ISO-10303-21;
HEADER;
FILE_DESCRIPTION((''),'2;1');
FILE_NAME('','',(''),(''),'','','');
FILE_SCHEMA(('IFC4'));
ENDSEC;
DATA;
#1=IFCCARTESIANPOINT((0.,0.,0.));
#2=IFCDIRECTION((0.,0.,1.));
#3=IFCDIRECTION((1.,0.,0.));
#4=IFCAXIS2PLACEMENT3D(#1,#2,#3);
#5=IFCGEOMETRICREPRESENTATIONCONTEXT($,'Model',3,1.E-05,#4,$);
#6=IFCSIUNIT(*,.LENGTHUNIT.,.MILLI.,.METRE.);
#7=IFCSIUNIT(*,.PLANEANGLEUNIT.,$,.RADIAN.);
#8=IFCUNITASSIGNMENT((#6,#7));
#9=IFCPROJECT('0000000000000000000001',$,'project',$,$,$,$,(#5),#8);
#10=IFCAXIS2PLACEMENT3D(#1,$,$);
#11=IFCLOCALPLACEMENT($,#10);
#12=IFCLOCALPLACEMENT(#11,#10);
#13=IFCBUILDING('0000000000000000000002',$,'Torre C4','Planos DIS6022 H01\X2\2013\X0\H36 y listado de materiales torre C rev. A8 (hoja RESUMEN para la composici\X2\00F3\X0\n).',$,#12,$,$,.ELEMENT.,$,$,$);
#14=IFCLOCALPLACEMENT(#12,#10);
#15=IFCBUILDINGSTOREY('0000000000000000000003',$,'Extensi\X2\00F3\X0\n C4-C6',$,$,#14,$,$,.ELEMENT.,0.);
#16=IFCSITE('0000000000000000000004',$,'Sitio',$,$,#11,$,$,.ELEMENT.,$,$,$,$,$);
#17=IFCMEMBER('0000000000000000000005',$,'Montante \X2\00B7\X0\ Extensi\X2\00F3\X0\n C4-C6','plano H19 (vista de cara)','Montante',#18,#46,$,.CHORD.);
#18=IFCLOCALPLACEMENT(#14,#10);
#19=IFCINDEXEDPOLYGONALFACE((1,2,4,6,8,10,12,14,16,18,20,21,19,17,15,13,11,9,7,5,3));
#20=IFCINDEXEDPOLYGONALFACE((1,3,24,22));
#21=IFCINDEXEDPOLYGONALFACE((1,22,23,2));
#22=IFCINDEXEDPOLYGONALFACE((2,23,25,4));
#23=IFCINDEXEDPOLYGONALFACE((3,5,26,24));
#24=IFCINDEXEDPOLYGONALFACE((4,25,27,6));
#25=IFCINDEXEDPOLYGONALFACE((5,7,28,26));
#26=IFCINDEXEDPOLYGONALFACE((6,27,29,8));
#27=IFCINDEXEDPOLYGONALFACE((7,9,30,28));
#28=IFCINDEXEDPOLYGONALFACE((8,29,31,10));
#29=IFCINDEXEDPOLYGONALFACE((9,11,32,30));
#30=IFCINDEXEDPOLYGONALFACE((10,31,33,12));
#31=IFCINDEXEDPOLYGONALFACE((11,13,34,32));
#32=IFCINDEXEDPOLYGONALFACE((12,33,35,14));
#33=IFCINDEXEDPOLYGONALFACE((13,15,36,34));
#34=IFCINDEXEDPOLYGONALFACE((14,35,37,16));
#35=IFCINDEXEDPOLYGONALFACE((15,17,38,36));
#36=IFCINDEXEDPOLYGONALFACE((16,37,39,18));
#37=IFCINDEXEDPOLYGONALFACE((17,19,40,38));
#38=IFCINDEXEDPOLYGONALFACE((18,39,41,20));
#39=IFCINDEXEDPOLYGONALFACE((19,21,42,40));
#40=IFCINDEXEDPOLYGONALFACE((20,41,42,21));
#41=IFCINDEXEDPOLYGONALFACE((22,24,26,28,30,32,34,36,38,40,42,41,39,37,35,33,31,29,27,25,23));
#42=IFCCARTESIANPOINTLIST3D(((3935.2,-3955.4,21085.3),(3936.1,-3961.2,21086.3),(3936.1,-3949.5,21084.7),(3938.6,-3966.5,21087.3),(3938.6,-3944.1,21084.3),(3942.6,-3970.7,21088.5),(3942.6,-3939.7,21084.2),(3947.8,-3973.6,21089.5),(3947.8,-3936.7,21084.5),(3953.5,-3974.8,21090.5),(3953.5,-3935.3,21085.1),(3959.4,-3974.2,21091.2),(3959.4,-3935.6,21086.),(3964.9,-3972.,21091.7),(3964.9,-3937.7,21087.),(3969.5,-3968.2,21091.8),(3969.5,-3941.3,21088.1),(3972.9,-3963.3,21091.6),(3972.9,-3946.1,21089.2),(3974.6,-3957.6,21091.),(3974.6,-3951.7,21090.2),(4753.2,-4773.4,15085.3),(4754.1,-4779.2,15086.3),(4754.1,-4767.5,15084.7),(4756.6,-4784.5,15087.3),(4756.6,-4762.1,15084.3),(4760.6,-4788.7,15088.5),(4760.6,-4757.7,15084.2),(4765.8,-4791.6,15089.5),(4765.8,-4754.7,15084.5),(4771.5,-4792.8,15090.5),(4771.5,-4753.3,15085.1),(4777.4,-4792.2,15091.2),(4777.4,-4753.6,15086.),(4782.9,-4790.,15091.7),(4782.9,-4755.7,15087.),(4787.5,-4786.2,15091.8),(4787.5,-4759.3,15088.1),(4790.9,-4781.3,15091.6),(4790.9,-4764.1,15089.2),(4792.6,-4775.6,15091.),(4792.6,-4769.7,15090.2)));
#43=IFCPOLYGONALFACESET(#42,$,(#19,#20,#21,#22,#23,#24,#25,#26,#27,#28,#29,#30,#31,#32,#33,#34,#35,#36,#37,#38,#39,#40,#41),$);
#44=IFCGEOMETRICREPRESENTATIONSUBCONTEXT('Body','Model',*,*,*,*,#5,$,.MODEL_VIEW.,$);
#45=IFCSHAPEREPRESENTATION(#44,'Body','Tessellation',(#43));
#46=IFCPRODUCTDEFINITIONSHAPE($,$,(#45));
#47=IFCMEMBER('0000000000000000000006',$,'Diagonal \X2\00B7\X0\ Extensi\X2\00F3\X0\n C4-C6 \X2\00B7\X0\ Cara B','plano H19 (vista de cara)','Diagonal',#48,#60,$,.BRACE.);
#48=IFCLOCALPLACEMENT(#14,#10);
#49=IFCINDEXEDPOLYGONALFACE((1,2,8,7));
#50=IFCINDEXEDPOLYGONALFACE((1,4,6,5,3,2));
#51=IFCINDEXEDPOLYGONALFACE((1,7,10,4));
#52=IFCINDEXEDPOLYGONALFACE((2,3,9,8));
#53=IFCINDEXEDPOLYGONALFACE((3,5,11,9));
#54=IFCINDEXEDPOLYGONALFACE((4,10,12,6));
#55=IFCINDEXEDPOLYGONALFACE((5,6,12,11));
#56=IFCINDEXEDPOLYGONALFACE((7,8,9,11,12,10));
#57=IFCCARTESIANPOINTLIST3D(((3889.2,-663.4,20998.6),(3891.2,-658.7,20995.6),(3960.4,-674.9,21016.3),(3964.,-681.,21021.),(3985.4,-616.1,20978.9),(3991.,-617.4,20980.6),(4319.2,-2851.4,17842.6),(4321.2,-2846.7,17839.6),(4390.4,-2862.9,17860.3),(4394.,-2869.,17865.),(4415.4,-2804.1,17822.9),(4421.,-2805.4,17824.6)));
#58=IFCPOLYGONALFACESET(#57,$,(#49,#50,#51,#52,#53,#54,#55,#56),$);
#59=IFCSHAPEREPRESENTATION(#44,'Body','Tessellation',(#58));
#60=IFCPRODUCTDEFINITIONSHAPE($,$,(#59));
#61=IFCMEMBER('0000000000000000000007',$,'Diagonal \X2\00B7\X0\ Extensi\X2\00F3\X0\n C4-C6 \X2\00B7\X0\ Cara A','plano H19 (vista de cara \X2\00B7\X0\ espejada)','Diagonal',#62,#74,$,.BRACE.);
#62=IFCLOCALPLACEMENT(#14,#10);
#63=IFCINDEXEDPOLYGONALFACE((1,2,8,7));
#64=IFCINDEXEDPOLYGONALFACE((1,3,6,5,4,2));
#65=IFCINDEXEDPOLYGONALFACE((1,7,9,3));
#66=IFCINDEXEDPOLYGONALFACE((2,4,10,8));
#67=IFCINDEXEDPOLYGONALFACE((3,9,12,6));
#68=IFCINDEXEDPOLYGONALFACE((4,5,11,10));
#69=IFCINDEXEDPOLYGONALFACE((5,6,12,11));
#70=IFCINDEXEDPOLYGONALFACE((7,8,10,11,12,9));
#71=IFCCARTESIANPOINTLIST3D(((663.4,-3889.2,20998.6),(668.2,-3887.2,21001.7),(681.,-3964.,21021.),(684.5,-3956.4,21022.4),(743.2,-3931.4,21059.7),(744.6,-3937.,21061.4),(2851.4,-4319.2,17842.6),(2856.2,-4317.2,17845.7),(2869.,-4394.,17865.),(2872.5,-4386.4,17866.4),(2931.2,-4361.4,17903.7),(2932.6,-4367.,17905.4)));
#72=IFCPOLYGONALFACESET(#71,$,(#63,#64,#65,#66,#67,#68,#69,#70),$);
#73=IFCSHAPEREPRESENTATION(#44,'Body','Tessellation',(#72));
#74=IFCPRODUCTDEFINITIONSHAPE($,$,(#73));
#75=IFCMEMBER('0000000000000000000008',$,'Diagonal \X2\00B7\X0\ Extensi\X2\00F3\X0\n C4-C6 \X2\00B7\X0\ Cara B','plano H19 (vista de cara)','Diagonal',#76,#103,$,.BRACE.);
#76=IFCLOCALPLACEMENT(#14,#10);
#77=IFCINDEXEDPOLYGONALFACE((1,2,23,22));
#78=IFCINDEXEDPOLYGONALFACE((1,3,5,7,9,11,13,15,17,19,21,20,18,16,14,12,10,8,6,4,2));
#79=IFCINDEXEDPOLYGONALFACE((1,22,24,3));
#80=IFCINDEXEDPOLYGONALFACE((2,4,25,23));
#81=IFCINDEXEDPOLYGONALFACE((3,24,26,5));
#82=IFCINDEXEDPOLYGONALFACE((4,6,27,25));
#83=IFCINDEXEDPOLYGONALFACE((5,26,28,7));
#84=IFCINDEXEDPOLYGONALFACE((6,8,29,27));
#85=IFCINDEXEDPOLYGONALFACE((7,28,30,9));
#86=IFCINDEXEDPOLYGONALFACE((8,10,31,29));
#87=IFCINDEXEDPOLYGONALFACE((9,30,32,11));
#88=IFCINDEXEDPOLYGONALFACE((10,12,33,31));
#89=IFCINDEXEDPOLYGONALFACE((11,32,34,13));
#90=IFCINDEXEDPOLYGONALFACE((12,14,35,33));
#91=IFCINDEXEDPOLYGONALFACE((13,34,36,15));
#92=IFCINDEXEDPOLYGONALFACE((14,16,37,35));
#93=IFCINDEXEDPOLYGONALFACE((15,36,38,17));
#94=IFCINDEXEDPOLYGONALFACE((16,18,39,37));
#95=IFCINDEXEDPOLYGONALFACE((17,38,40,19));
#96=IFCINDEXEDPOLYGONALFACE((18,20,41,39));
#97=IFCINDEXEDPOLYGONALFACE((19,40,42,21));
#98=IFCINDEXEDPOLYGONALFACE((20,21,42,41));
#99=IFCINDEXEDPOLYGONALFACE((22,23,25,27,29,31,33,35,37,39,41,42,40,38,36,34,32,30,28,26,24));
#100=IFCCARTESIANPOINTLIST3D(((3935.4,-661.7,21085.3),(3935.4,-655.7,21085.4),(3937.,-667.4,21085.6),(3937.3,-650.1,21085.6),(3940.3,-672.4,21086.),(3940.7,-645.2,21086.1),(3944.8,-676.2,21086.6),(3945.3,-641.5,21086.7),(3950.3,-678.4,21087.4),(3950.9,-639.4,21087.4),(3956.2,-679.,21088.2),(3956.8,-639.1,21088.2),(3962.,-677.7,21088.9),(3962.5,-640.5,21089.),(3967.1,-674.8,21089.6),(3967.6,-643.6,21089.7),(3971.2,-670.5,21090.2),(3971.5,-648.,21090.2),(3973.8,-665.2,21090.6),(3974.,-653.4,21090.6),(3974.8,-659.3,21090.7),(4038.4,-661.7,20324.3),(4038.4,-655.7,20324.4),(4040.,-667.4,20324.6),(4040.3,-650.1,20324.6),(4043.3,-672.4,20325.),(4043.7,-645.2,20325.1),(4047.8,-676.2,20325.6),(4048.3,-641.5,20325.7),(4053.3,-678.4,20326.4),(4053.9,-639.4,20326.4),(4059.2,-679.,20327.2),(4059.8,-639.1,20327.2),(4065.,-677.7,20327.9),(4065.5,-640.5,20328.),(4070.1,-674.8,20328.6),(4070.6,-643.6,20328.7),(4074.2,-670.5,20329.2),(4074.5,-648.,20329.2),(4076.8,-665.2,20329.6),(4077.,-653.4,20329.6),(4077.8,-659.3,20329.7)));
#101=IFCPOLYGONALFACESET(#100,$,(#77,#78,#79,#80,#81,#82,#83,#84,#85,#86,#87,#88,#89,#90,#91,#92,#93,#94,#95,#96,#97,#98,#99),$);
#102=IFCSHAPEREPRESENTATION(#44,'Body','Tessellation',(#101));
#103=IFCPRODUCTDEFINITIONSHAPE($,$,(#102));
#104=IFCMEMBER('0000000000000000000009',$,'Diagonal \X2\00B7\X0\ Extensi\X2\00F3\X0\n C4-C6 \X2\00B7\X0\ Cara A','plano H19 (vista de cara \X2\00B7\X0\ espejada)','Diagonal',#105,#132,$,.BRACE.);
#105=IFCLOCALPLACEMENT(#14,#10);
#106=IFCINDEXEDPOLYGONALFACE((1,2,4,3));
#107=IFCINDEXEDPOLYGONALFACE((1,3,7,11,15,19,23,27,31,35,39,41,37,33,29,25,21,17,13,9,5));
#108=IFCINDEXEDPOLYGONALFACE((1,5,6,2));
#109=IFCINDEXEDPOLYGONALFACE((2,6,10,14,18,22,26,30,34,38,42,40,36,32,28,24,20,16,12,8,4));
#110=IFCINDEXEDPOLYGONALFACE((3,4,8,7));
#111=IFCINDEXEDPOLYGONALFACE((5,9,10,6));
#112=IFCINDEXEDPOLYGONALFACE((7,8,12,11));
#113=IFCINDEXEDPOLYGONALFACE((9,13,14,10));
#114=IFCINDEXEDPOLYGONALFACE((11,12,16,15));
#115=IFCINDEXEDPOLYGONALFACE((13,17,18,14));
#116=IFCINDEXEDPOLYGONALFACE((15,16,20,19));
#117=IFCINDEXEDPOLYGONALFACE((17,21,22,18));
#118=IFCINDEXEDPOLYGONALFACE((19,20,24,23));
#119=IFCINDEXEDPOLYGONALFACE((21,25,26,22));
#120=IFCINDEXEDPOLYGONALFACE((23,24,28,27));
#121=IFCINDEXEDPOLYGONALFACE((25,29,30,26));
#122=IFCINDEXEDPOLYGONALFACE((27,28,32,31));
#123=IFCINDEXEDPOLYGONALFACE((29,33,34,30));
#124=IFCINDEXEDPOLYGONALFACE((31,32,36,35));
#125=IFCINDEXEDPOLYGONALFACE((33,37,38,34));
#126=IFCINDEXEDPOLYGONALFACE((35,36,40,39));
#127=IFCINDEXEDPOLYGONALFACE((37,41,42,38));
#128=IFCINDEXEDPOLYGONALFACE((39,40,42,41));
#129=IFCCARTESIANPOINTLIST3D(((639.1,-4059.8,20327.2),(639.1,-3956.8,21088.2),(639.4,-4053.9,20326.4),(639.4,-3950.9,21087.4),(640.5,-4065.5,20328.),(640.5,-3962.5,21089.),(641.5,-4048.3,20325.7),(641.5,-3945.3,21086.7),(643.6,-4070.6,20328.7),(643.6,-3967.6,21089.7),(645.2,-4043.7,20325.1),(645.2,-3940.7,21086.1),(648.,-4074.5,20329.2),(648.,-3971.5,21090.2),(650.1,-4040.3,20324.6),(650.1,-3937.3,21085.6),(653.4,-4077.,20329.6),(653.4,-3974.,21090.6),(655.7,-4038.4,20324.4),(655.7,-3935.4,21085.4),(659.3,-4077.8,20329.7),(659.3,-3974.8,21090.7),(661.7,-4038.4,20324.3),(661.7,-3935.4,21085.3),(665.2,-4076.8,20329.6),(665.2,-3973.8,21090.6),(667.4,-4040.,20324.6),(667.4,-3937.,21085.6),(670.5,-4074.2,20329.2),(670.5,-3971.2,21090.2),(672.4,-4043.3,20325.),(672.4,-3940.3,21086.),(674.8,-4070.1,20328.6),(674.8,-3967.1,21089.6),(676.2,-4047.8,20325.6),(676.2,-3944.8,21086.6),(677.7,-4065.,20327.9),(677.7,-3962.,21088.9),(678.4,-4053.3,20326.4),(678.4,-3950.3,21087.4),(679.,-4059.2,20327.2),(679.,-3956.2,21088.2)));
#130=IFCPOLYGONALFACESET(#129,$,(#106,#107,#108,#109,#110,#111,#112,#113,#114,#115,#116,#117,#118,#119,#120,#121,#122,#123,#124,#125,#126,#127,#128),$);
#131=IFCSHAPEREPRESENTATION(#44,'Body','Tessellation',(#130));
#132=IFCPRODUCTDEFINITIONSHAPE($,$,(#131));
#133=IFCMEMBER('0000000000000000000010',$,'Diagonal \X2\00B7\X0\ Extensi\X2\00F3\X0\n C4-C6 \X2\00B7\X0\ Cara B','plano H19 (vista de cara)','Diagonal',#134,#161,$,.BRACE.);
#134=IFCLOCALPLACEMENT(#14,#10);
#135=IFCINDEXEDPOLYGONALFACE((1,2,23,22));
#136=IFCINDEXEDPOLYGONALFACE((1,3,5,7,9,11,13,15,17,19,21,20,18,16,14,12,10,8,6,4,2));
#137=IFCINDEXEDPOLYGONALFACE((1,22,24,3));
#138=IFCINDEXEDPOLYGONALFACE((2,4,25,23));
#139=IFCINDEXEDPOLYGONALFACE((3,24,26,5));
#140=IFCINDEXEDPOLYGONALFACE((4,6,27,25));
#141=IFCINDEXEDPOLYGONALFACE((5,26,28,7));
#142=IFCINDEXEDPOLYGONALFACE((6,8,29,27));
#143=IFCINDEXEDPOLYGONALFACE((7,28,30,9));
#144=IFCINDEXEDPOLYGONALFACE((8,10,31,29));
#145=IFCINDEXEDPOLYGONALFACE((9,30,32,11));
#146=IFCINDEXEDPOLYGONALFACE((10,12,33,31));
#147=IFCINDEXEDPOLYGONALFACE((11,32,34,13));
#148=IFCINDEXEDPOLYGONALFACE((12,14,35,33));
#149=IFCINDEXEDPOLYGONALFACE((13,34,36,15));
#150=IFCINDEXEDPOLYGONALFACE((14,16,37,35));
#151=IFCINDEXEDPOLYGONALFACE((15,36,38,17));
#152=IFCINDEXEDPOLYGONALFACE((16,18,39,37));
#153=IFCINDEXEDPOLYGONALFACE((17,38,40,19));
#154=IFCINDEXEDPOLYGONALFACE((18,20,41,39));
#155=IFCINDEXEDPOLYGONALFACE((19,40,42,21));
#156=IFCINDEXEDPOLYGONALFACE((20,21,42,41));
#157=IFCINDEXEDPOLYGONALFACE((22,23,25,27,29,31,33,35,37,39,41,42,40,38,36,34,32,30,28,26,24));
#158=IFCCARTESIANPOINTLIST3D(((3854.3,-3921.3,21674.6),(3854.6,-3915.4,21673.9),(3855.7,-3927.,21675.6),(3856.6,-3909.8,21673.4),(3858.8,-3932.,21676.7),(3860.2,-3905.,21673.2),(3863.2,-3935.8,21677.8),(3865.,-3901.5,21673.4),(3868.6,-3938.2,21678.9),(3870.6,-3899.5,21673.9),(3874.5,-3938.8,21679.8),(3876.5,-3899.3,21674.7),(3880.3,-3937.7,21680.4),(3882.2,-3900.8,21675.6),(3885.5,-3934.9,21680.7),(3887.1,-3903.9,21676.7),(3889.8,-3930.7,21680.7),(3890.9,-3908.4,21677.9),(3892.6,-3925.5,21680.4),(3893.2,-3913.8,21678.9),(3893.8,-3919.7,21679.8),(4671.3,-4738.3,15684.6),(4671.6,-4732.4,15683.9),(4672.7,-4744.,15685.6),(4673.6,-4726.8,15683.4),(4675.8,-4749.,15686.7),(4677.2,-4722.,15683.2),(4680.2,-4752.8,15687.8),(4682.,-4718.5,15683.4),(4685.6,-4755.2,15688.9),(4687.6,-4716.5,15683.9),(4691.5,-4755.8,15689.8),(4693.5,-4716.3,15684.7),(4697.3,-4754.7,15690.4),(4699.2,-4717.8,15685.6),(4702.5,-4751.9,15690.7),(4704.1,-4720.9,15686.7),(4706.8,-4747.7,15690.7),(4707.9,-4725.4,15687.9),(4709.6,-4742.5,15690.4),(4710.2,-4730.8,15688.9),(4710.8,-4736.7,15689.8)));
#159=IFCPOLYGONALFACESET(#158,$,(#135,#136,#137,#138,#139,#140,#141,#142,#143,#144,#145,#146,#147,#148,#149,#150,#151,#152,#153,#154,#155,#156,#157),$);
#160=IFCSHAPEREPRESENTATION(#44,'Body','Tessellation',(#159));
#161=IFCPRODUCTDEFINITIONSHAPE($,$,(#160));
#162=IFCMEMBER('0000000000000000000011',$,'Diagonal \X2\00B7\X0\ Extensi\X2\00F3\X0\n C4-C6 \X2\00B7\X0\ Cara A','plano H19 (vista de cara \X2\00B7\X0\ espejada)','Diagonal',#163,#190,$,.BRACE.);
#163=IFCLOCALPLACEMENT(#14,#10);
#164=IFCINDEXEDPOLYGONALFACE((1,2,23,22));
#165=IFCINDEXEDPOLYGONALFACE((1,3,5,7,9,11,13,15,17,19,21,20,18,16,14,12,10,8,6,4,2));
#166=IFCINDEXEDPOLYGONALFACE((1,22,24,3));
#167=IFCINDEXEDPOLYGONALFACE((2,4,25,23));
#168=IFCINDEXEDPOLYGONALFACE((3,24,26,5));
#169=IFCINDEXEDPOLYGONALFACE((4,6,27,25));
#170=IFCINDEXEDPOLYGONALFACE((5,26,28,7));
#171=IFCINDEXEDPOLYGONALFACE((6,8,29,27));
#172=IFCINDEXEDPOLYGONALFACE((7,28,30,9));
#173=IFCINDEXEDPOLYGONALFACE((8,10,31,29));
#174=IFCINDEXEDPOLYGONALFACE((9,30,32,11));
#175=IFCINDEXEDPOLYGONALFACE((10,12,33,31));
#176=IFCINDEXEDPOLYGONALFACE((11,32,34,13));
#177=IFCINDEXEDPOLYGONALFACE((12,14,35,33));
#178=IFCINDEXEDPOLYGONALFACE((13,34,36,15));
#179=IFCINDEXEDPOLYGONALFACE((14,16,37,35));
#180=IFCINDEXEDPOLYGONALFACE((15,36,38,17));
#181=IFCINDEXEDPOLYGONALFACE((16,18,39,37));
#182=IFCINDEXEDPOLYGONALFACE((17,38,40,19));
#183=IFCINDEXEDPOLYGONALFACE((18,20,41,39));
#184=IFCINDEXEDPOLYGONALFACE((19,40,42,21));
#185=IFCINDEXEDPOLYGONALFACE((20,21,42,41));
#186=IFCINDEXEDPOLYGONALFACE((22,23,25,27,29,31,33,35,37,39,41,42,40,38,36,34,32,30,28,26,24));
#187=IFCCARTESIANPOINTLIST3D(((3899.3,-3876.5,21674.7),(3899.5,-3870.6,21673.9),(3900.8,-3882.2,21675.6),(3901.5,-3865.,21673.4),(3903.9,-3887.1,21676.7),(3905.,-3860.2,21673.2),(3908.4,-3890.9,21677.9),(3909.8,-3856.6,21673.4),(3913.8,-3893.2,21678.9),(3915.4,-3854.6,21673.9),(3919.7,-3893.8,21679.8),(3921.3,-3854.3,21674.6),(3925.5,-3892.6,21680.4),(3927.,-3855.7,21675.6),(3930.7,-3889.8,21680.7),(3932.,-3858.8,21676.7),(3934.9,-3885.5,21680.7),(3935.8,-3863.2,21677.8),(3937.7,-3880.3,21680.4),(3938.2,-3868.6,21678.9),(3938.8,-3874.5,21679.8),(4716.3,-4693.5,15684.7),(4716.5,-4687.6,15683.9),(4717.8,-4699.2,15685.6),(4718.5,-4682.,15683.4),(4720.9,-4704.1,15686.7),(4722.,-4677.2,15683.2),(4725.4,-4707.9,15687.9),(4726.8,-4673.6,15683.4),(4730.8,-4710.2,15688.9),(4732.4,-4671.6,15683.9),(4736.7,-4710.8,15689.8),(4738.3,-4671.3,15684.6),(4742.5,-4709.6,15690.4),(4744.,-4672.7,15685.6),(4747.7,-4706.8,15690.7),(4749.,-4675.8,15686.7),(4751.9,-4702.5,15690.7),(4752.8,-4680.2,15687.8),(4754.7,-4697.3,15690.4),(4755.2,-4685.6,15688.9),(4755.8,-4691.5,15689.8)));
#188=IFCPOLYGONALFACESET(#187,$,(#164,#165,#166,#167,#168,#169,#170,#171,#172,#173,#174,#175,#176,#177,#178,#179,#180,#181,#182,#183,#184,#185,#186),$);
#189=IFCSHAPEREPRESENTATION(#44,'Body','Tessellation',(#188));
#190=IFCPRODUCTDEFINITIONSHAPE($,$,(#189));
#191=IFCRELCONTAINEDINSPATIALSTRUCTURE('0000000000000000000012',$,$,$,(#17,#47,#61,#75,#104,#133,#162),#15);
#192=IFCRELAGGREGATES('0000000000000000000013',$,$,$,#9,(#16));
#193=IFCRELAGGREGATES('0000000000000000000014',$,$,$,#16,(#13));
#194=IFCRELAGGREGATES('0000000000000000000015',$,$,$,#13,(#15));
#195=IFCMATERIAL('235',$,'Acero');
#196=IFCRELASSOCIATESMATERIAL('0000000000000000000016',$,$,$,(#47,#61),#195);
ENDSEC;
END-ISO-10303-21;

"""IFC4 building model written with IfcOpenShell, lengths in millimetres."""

from ifc_helpers import new_model, si_unit, frame, frame_2d, origin, origin_with_axes, place, context, subcontext, project, spatial, circle, l_section, extrude, material, element, save


model = new_model("IFC4")

# Units and contexts
model_context = context("Model", 3, precision=1e-05, world=origin_with_axes())
body_context = subcontext(model_context, "Body", "Model", "MODEL_VIEW")
ifc_project = project(units=[si_unit("LENGTHUNIT", "METRE", prefix="MILLI"), si_unit("PLANEANGLEUNIT", "RADIAN")], contexts=[model_context])

# Site, building, storey
site_placement = place(None, origin())
site = spatial("IfcSite", under=ifc_project, at=site_placement, Name="Sitio", CompositionType="ELEMENT")
building_placement = place(site_placement, origin())
building = spatial("IfcBuilding", under=site, at=building_placement, Name="Torre C4", Description="Planos DIS6022 H01–H36 y listado de materiales torre C rev. A8 (hoja RESUMEN para la composición).", CompositionType="ELEMENT")
storey_placement = place(building_placement, origin())
storey = spatial("IfcBuildingStorey", under=building, at=storey_placement, Name="Extensión C4-C6", CompositionType="ELEMENT", Elevation=0.0)

# Members
member_placement = place(storey_placement, frame((3955.0, -3955.0, 21088.0), z_axis=(0.133868, -0.133868, -0.981916), x_axis=(-0.990999, -0.018083, -0.132641)))
element("IfcMember", 1, at=member_placement, inside=storey, Name="Montante · Extensión C4-C6", Description="plano H19 (vista de cara)", ObjectType="Montante", PredefinedType="CHORD", context=body_context, shape_type="SweptSolid", body=[
    extrude(circle(Radius=20.0), None, (0.0, 0.0, 1.0), 6110.5),
])
ifc_material = material(Name="235", Category="Acero")
for number, where, z_axis, x_axis, name, description in (
    (2, (3964.0, -681.0, 21021.0), (0.111276, -0.566213, -0.816713), (-0.934738, 0.219434, -0.279487), "Diagonal · Extensión C4-C6 · Cara B", "plano H19 (vista de cara)"),
    (3, (681.0, -3964.0, 21021.0), (0.566213, -0.111276, -0.816713), (-0.219434, 0.934738, -0.279487), "Diagonal · Extensión C4-C6 · Cara A", "plano H19 (vista de cara · espejada)"),
):
    element("IfcMember", number, at=place(storey_placement, frame(where, z_axis=z_axis, x_axis=x_axis)), inside=storey, material=ifc_material, Name=name, Description=description, ObjectType="Diagonal", PredefinedType="BRACE", context=body_context, shape_type="SweptSolid", body=[
        extrude(l_section(Depth=80.0, Width=80.0, Thickness=6.0, at=frame_2d((40.0, 40.0))), None, (0.0, 0.0, 1.0), 3864.3),
    ])
for number, where, z_axis, x_axis, name, description in (
    (4, (4058.0, -659.0, 20327.0), (-0.134125, 0.0, 0.990964), (-0.977589, 0.163742, -0.132315), "Diagonal · Extensión C4-C6 · Cara B", "plano H19 (vista de cara)"),
    (5, (659.0, -4058.0, 20327.0), (0.0, 0.134125, 0.990964), (-0.163742, 0.977589, -0.132315), "Diagonal · Extensión C4-C6 · Cara A", "plano H19 (vista de cara · espejada)"),
):
    element("IfcMember", number, at=place(storey_placement, frame(where, z_axis=z_axis, x_axis=x_axis)), inside=storey, Name=name, Description=description, ObjectType="Diagonal", PredefinedType="BRACE", context=body_context, shape_type="SweptSolid", body=[
        extrude(circle(Radius=20.0), None, (0.0, 0.0, 1.0), 767.9),
    ])
for number, where, z_axis, x_axis, name, description in (
    (6, (4691.0, -4736.0, 15687.0), (-0.133925, 0.133925, 0.9819), (-0.690535, 0.698062, -0.189396), "Diagonal · Extensión C4-C6 · Cara B", "plano H19 (vista de cara)"),
    (7, (4736.0, -4691.0, 15687.0), (-0.133925, 0.133925, 0.9819), (-0.698062, 0.690535, -0.189396), "Diagonal · Extensión C4-C6 · Cara A", "plano H19 (vista de cara · espejada)"),
):
    element("IfcMember", number, at=place(storey_placement, frame(where, z_axis=z_axis, x_axis=x_axis)), inside=storey, Name=name, Description=description, ObjectType="Diagonal", PredefinedType="BRACE", context=body_context, shape_type="SweptSolid", body=[
        extrude(circle(Radius=20.0), None, (0.0, 0.0, 1.0), 6100.4),
    ])

save(model, "model.ifc")
